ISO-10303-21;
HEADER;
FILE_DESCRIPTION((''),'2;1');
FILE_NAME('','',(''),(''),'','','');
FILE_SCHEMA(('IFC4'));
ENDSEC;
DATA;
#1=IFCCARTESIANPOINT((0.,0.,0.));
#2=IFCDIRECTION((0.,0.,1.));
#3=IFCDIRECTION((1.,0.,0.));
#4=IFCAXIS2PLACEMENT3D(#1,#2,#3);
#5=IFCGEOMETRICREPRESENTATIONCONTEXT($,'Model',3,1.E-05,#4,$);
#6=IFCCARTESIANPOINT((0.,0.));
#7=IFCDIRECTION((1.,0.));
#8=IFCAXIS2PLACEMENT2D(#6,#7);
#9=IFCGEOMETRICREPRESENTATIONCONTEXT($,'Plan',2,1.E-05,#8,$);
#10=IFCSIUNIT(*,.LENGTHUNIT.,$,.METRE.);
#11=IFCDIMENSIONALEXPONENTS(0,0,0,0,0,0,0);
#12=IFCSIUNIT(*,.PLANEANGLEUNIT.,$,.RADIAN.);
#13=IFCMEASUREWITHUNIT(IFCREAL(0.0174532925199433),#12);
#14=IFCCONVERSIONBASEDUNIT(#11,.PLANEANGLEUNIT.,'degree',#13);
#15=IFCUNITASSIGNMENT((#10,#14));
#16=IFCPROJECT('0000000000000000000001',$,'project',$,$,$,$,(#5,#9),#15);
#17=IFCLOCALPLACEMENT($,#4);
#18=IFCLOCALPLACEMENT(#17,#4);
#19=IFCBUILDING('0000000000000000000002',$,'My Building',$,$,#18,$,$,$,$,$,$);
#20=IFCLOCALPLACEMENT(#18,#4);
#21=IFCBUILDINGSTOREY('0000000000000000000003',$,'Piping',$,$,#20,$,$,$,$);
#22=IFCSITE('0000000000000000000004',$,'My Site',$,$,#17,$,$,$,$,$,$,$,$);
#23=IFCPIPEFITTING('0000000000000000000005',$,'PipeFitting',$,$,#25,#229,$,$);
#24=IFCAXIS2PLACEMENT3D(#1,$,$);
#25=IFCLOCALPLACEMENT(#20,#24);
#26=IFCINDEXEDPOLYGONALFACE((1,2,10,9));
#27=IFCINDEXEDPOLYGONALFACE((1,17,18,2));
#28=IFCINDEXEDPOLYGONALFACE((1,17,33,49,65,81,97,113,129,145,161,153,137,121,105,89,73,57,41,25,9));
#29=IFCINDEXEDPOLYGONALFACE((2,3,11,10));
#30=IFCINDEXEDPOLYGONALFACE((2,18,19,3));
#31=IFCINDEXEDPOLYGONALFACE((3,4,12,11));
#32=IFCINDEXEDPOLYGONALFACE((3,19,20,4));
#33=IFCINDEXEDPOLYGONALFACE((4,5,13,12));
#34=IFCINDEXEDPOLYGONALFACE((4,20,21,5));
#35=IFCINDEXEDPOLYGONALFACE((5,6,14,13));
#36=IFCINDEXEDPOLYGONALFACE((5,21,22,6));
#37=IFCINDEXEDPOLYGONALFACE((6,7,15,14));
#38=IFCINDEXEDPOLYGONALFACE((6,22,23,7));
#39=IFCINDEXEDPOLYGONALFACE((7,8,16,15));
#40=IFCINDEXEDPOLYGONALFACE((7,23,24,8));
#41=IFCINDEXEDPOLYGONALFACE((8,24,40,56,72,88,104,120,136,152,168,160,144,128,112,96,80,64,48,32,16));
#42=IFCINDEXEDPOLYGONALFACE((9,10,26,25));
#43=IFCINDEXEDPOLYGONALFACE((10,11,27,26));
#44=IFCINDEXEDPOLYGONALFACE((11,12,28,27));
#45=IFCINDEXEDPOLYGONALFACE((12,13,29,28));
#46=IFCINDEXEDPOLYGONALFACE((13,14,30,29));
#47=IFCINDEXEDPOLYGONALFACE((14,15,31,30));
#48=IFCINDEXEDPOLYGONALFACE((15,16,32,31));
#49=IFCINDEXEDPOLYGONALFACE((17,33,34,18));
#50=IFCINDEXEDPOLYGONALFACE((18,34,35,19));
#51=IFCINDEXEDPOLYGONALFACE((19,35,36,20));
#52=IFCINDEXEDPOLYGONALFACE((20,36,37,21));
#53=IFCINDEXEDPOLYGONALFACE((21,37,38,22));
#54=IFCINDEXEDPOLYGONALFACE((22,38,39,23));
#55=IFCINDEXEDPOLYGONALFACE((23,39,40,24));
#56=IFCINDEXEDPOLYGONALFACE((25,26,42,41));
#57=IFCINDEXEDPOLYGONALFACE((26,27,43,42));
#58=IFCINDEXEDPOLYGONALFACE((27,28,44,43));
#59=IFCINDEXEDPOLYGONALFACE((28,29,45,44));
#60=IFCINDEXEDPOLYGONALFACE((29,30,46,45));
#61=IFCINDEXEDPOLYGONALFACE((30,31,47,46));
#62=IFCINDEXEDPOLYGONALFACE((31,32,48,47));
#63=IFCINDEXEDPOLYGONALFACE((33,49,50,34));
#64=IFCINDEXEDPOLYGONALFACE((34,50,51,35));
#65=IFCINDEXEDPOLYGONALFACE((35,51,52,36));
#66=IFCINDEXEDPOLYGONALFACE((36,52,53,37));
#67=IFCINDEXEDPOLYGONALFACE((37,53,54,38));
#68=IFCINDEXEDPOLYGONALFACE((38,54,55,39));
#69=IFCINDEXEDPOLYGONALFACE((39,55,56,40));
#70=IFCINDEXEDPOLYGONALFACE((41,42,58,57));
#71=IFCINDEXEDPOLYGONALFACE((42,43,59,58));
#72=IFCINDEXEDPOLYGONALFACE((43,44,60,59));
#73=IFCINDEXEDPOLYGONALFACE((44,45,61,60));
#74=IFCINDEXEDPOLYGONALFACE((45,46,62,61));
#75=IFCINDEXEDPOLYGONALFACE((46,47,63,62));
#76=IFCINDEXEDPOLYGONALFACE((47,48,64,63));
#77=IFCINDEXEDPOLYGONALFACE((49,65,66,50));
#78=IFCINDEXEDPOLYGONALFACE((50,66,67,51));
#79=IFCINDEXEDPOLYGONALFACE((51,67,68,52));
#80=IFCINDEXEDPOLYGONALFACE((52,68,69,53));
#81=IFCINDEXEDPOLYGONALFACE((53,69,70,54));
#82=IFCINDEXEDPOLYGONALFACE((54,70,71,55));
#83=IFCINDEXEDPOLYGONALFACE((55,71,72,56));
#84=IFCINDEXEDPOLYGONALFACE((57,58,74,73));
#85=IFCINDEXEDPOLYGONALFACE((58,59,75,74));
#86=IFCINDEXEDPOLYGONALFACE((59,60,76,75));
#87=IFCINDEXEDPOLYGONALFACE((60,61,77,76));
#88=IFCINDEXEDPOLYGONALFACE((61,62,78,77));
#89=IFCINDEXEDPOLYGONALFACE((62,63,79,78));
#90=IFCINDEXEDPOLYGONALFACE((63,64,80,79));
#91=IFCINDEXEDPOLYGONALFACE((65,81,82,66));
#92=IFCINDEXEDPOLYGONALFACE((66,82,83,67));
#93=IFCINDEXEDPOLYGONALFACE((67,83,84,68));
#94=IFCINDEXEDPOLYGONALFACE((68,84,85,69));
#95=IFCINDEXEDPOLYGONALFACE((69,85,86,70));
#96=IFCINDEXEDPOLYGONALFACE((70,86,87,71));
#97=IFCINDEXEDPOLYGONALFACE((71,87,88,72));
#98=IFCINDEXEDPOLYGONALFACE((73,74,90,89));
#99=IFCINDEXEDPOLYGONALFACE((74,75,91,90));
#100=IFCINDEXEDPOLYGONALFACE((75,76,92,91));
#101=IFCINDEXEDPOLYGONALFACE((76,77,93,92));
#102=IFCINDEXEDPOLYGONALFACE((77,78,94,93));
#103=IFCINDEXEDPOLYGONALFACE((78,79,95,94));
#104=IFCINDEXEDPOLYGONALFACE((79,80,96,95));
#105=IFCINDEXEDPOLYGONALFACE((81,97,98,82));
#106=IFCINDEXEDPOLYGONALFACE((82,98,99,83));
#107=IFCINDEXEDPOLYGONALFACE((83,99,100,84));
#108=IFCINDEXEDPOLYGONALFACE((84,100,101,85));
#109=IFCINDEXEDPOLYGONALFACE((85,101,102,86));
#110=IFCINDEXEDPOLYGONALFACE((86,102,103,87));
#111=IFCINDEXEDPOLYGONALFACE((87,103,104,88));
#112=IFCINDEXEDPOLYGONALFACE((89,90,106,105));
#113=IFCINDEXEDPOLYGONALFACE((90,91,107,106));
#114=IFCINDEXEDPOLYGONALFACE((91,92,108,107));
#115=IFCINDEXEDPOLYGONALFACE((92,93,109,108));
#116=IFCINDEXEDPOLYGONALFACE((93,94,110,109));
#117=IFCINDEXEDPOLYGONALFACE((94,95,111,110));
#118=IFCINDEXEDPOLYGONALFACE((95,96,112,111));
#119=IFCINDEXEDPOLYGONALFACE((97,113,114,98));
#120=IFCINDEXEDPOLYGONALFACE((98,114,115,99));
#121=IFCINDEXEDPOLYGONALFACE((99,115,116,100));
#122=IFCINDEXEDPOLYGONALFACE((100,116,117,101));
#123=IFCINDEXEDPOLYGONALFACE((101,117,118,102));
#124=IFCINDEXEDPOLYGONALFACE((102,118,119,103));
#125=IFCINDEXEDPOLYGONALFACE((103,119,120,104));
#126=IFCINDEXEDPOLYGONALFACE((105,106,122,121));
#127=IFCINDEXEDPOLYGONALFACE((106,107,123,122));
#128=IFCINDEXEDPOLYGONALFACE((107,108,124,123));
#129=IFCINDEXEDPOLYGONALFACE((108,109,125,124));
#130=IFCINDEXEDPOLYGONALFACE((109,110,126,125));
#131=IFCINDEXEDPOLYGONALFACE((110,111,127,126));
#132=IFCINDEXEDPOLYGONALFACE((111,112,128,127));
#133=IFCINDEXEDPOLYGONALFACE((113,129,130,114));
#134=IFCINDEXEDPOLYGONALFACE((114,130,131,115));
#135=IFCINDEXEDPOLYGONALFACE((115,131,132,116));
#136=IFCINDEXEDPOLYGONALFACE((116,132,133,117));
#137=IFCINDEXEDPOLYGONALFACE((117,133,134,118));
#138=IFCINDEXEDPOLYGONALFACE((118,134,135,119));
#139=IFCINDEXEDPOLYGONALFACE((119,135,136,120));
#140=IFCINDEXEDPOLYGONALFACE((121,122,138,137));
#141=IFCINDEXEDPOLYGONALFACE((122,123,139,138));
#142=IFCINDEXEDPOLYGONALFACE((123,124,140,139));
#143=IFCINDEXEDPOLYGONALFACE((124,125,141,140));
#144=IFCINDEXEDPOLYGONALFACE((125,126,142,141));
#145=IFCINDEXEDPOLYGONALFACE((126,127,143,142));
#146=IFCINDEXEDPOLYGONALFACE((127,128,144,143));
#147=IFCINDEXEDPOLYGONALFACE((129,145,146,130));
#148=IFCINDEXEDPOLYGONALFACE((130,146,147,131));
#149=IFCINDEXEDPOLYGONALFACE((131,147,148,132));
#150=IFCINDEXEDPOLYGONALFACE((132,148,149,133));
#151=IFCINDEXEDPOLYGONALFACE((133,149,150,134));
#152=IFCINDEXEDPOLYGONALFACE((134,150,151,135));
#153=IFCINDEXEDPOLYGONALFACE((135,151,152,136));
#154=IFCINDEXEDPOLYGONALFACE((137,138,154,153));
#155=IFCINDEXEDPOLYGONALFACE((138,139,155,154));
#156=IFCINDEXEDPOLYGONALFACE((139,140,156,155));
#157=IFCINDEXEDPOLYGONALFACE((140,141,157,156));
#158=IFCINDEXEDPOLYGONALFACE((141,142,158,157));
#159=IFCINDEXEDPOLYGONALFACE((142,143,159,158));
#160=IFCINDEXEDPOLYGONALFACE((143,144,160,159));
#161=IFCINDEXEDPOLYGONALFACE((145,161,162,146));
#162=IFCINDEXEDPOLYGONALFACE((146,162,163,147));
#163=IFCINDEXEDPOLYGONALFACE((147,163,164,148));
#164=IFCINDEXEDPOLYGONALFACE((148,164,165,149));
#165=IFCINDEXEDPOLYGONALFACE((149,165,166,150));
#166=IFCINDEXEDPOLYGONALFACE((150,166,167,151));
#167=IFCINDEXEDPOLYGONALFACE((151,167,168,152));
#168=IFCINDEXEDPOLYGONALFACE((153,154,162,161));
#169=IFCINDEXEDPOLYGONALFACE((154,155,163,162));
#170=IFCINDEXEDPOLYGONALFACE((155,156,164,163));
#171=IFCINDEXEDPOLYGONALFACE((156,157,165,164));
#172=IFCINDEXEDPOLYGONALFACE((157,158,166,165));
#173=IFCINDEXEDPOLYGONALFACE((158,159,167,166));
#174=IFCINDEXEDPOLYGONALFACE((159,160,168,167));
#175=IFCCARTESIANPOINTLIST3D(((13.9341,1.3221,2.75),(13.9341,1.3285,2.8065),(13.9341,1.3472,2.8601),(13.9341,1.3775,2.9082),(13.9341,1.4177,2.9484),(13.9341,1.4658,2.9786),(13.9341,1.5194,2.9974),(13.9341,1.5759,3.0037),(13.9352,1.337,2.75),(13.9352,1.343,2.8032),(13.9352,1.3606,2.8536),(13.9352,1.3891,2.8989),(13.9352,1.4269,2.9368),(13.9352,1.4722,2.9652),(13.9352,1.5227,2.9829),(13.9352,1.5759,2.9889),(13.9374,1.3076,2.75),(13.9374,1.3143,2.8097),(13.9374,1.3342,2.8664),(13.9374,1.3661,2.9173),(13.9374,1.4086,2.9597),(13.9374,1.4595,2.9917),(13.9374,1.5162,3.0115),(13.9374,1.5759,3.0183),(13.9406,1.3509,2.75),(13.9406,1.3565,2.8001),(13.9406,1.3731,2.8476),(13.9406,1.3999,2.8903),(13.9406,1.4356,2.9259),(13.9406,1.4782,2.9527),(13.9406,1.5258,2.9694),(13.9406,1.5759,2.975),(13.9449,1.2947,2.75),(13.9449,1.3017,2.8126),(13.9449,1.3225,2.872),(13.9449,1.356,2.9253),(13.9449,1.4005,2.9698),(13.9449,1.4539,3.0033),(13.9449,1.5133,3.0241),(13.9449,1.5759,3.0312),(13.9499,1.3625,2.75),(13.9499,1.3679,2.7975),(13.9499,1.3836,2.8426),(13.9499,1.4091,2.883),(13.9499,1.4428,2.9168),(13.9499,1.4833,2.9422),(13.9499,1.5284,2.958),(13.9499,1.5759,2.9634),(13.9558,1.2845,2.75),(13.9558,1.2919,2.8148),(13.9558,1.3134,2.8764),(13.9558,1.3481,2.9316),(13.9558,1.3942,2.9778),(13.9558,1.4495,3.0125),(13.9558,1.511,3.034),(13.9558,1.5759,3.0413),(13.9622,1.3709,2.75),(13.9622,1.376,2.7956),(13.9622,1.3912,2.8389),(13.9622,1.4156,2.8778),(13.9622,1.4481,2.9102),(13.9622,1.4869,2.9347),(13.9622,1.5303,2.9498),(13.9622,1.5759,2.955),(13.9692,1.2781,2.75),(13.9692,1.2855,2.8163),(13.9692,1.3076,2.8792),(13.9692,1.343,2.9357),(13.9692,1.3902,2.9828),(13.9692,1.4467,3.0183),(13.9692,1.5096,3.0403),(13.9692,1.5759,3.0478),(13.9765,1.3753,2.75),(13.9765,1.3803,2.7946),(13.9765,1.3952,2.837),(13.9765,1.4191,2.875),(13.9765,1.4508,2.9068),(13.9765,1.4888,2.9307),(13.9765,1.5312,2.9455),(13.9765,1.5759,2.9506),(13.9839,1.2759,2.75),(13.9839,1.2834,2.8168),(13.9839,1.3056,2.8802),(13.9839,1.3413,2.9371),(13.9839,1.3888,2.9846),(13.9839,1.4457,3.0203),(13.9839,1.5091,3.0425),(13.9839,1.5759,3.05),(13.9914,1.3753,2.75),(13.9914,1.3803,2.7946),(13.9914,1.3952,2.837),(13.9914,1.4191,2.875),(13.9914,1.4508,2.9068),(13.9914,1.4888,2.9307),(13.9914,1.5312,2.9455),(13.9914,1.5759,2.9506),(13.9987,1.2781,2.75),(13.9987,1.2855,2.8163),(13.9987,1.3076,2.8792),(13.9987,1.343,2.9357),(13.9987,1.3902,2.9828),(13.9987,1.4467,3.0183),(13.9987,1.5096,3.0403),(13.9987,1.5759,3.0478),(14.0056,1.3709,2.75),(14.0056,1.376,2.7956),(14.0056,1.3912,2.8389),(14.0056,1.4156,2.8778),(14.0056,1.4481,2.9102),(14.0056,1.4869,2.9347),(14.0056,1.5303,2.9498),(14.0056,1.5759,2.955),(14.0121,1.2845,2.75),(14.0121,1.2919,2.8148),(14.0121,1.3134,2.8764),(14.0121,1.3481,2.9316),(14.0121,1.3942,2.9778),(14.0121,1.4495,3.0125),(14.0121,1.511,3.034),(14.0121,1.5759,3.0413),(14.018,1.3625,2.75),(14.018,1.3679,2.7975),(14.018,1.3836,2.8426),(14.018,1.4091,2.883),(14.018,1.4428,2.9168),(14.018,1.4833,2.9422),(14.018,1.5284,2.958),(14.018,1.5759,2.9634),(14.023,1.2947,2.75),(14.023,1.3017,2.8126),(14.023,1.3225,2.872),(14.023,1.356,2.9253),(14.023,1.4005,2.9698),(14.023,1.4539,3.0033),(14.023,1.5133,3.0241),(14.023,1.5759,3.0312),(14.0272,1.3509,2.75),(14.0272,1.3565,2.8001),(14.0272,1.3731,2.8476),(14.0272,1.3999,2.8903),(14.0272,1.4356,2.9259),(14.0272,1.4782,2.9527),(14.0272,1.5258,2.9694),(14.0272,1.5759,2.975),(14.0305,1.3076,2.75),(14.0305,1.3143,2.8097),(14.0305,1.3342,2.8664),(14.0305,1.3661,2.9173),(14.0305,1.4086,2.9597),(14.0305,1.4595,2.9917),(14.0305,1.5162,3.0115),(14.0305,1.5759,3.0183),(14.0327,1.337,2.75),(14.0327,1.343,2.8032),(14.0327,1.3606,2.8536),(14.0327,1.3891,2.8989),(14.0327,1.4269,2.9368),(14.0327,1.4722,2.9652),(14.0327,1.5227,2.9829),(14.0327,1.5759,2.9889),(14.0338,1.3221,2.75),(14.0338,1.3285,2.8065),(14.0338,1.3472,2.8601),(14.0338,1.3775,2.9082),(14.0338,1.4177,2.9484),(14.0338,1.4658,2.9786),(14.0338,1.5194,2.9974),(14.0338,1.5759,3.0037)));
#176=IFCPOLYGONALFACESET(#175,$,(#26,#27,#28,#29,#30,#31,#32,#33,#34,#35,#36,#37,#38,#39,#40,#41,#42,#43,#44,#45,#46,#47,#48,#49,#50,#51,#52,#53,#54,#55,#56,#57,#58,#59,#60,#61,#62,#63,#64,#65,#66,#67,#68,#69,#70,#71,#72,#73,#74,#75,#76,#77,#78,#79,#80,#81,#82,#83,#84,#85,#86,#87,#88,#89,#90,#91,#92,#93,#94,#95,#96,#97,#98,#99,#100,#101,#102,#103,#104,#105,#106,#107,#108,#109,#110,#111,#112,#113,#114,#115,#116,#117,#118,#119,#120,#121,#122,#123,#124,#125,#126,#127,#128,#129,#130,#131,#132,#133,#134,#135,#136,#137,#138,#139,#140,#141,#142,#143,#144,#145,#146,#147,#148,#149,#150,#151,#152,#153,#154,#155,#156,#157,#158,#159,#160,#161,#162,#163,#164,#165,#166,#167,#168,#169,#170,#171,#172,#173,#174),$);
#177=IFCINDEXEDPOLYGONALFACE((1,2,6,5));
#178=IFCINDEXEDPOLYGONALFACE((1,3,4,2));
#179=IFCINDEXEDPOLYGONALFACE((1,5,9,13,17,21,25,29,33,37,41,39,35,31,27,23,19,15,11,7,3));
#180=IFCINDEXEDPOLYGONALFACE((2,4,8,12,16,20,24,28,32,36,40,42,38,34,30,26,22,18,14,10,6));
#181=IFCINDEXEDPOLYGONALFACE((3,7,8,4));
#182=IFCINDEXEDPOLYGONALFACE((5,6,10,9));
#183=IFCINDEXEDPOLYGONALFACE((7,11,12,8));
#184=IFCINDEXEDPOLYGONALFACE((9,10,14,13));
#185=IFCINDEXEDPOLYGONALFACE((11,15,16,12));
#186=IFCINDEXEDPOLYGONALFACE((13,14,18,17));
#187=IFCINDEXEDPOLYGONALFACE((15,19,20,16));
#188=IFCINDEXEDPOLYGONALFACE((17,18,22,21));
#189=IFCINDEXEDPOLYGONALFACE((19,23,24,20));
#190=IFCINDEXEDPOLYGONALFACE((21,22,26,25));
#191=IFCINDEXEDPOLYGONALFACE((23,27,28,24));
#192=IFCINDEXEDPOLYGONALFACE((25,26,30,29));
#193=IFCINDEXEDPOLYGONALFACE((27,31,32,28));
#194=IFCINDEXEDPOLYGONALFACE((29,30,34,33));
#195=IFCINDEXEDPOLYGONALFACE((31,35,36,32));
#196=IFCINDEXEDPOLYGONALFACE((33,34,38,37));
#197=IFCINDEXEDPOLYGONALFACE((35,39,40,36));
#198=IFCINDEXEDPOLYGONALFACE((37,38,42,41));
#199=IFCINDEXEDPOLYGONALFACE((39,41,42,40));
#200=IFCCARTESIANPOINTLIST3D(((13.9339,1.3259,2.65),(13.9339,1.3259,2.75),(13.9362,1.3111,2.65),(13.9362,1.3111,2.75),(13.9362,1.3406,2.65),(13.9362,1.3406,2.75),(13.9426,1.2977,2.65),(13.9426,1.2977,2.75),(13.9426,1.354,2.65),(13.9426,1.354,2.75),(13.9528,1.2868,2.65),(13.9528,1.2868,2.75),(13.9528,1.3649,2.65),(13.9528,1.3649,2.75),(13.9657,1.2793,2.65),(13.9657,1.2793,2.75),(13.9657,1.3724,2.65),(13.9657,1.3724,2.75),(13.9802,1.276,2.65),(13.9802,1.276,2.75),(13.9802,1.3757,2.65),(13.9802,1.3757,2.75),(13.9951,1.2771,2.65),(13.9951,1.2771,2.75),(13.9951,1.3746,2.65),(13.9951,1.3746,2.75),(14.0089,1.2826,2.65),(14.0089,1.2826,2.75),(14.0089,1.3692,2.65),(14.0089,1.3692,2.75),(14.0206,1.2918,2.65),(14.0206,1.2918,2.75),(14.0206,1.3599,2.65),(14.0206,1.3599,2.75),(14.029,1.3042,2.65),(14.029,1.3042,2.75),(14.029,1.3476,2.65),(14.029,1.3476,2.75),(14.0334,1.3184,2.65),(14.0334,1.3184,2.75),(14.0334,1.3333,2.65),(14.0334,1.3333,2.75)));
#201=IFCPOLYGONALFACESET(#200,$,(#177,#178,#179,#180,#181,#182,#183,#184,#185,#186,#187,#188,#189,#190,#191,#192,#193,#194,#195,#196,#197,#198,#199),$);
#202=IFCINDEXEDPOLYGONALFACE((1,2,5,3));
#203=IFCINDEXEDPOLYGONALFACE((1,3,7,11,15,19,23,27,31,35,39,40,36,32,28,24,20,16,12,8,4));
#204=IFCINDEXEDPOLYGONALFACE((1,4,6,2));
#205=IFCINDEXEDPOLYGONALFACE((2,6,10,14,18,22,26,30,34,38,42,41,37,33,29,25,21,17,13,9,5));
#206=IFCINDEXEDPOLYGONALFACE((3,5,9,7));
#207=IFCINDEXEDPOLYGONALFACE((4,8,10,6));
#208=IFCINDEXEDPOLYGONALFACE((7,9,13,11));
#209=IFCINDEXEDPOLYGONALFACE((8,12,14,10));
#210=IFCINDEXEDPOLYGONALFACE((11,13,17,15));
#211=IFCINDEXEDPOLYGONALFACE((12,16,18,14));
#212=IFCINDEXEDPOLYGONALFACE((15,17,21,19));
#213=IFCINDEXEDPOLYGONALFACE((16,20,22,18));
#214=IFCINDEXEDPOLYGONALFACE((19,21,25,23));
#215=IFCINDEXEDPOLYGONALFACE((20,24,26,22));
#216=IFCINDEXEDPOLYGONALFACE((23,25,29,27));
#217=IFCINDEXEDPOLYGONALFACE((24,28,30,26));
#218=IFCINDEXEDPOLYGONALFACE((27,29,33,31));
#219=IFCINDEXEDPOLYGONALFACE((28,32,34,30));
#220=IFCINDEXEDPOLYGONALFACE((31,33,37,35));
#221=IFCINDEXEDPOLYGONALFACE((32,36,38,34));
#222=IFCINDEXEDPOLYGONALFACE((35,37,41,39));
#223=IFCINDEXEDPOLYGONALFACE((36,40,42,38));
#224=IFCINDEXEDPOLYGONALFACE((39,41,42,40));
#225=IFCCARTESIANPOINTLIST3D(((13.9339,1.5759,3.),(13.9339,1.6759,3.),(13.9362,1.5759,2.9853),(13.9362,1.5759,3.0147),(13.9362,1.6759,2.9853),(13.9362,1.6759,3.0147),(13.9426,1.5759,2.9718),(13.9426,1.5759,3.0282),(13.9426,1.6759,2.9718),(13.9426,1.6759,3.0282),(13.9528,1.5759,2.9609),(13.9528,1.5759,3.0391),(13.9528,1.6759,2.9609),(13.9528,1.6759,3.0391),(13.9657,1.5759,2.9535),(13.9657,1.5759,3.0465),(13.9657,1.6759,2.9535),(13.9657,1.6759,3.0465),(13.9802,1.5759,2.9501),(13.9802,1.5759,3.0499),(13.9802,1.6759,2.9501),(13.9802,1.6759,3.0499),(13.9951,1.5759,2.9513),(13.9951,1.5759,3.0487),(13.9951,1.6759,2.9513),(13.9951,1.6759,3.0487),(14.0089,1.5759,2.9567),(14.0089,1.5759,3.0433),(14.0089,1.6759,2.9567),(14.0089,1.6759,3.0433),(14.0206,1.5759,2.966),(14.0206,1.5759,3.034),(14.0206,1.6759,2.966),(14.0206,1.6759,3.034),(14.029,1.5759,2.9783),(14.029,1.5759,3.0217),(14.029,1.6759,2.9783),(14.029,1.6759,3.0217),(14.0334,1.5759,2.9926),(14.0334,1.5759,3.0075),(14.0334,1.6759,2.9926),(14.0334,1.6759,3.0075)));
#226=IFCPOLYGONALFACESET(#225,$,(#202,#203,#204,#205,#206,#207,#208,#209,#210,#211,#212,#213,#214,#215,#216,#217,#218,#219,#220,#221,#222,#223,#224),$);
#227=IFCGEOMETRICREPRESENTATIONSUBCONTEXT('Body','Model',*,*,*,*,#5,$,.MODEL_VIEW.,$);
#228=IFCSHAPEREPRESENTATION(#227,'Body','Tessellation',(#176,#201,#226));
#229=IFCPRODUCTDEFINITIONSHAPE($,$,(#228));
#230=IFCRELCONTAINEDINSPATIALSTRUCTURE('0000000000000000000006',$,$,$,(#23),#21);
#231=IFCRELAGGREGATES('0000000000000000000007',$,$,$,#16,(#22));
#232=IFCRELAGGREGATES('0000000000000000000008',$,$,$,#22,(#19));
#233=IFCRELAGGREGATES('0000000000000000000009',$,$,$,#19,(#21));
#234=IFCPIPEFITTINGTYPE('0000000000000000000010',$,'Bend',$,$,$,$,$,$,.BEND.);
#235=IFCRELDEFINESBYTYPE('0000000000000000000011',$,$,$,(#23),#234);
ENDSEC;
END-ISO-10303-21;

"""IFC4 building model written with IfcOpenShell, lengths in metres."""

from ifc_helpers import new_model, entity, si_unit, converted_unit, frame, origin_with_axes, origin_2d_with_axis, place, context, subcontext, project, spatial, circle, extrude, source, transform, mapped, type_object, type_shapes, element, save


model = new_model("IFC4")

# Units and contexts
model_context = context("Model", 3, precision=1e-05, world=origin_with_axes())
plan_context = context("Plan", 2, precision=1e-05, world=origin_2d_with_axis())
body_context = subcontext(model_context, "Body", "Model", "MODEL_VIEW")
ifc_project = project(units=[si_unit("LENGTHUNIT", "METRE"), converted_unit("PLANEANGLEUNIT", "degree", entity("IfcReal", 0.0174532925199433), si_unit("PLANEANGLEUNIT", "RADIAN"), dimensions=[0, 0, 0, 0, 0, 0, 0])], contexts=[model_context, plan_context])

# Site, building, storey
site_placement = place(None, origin_with_axes())
site = spatial("IfcSite", under=ifc_project, at=site_placement, Name="My Site")
building_placement = place(site_placement, origin_with_axes())
building = spatial("IfcBuilding", under=site, at=building_placement, Name="My Building")
storey_placement = place(building_placement, origin_with_axes())
storey = spatial("IfcBuildingStorey", under=building, at=storey_placement, Name="Piping")

# Pipe fitting
pipe_fitting_type = type_object("IfcPipeFittingType", Name="Bend", PredefinedType="BEND")
shared_shape = source(origin_with_axes(), body_context, "Body", "SolidModel", [
    entity("IfcSweptDiskSolid", entity("IfcIndexedPolyCurve", entity("IfcCartesianPointList3D", [[0.0, 0.0, -0.1], [0.0, 0.0732, -0.2768], [0.0, 0.25, -0.35]]), [entity("IfcArcIndex", [1, 2, 3])]), 0.05),
    extrude(circle(Radius=0.05), origin_with_axes(), (0.0, 0.0, -1.0), 0.1),
    extrude(circle(Radius=0.05), frame((0.0, 0.25, -0.35), z_axis=(0.0, 1.0, 0.0), x_axis=(1.0, 0.0, 0.0)), (0.0, 0.0, 1.0), 0.1),
])
type_shapes(pipe_fitting_type, [shared_shape])
for number, where, z_axis, x_axis, name in (
    (1, (13.9839, 1.3259, 2.65), (0.0, 0.0, -1.0), (-1.0, 0.0, 0.0), "PipeFitting"),
):
    element("IfcPipeFitting", number, at=place(storey_placement, frame(where, z_axis=z_axis, x_axis=x_axis)), inside=storey, type_object=pipe_fitting_type, Name=name, context=body_context, shape_type="MappedRepresentation", body=[
        mapped(shared_shape, transform((0.0, 0.0, 0.0), x_axis=(1.0, 0.0, 0.0), y_axis=(0.0, 1.0, 0.0), z_axis=(0.0, 0.0, 1.0), scale=1.0)),
    ])

save(model, "model.ifc")
